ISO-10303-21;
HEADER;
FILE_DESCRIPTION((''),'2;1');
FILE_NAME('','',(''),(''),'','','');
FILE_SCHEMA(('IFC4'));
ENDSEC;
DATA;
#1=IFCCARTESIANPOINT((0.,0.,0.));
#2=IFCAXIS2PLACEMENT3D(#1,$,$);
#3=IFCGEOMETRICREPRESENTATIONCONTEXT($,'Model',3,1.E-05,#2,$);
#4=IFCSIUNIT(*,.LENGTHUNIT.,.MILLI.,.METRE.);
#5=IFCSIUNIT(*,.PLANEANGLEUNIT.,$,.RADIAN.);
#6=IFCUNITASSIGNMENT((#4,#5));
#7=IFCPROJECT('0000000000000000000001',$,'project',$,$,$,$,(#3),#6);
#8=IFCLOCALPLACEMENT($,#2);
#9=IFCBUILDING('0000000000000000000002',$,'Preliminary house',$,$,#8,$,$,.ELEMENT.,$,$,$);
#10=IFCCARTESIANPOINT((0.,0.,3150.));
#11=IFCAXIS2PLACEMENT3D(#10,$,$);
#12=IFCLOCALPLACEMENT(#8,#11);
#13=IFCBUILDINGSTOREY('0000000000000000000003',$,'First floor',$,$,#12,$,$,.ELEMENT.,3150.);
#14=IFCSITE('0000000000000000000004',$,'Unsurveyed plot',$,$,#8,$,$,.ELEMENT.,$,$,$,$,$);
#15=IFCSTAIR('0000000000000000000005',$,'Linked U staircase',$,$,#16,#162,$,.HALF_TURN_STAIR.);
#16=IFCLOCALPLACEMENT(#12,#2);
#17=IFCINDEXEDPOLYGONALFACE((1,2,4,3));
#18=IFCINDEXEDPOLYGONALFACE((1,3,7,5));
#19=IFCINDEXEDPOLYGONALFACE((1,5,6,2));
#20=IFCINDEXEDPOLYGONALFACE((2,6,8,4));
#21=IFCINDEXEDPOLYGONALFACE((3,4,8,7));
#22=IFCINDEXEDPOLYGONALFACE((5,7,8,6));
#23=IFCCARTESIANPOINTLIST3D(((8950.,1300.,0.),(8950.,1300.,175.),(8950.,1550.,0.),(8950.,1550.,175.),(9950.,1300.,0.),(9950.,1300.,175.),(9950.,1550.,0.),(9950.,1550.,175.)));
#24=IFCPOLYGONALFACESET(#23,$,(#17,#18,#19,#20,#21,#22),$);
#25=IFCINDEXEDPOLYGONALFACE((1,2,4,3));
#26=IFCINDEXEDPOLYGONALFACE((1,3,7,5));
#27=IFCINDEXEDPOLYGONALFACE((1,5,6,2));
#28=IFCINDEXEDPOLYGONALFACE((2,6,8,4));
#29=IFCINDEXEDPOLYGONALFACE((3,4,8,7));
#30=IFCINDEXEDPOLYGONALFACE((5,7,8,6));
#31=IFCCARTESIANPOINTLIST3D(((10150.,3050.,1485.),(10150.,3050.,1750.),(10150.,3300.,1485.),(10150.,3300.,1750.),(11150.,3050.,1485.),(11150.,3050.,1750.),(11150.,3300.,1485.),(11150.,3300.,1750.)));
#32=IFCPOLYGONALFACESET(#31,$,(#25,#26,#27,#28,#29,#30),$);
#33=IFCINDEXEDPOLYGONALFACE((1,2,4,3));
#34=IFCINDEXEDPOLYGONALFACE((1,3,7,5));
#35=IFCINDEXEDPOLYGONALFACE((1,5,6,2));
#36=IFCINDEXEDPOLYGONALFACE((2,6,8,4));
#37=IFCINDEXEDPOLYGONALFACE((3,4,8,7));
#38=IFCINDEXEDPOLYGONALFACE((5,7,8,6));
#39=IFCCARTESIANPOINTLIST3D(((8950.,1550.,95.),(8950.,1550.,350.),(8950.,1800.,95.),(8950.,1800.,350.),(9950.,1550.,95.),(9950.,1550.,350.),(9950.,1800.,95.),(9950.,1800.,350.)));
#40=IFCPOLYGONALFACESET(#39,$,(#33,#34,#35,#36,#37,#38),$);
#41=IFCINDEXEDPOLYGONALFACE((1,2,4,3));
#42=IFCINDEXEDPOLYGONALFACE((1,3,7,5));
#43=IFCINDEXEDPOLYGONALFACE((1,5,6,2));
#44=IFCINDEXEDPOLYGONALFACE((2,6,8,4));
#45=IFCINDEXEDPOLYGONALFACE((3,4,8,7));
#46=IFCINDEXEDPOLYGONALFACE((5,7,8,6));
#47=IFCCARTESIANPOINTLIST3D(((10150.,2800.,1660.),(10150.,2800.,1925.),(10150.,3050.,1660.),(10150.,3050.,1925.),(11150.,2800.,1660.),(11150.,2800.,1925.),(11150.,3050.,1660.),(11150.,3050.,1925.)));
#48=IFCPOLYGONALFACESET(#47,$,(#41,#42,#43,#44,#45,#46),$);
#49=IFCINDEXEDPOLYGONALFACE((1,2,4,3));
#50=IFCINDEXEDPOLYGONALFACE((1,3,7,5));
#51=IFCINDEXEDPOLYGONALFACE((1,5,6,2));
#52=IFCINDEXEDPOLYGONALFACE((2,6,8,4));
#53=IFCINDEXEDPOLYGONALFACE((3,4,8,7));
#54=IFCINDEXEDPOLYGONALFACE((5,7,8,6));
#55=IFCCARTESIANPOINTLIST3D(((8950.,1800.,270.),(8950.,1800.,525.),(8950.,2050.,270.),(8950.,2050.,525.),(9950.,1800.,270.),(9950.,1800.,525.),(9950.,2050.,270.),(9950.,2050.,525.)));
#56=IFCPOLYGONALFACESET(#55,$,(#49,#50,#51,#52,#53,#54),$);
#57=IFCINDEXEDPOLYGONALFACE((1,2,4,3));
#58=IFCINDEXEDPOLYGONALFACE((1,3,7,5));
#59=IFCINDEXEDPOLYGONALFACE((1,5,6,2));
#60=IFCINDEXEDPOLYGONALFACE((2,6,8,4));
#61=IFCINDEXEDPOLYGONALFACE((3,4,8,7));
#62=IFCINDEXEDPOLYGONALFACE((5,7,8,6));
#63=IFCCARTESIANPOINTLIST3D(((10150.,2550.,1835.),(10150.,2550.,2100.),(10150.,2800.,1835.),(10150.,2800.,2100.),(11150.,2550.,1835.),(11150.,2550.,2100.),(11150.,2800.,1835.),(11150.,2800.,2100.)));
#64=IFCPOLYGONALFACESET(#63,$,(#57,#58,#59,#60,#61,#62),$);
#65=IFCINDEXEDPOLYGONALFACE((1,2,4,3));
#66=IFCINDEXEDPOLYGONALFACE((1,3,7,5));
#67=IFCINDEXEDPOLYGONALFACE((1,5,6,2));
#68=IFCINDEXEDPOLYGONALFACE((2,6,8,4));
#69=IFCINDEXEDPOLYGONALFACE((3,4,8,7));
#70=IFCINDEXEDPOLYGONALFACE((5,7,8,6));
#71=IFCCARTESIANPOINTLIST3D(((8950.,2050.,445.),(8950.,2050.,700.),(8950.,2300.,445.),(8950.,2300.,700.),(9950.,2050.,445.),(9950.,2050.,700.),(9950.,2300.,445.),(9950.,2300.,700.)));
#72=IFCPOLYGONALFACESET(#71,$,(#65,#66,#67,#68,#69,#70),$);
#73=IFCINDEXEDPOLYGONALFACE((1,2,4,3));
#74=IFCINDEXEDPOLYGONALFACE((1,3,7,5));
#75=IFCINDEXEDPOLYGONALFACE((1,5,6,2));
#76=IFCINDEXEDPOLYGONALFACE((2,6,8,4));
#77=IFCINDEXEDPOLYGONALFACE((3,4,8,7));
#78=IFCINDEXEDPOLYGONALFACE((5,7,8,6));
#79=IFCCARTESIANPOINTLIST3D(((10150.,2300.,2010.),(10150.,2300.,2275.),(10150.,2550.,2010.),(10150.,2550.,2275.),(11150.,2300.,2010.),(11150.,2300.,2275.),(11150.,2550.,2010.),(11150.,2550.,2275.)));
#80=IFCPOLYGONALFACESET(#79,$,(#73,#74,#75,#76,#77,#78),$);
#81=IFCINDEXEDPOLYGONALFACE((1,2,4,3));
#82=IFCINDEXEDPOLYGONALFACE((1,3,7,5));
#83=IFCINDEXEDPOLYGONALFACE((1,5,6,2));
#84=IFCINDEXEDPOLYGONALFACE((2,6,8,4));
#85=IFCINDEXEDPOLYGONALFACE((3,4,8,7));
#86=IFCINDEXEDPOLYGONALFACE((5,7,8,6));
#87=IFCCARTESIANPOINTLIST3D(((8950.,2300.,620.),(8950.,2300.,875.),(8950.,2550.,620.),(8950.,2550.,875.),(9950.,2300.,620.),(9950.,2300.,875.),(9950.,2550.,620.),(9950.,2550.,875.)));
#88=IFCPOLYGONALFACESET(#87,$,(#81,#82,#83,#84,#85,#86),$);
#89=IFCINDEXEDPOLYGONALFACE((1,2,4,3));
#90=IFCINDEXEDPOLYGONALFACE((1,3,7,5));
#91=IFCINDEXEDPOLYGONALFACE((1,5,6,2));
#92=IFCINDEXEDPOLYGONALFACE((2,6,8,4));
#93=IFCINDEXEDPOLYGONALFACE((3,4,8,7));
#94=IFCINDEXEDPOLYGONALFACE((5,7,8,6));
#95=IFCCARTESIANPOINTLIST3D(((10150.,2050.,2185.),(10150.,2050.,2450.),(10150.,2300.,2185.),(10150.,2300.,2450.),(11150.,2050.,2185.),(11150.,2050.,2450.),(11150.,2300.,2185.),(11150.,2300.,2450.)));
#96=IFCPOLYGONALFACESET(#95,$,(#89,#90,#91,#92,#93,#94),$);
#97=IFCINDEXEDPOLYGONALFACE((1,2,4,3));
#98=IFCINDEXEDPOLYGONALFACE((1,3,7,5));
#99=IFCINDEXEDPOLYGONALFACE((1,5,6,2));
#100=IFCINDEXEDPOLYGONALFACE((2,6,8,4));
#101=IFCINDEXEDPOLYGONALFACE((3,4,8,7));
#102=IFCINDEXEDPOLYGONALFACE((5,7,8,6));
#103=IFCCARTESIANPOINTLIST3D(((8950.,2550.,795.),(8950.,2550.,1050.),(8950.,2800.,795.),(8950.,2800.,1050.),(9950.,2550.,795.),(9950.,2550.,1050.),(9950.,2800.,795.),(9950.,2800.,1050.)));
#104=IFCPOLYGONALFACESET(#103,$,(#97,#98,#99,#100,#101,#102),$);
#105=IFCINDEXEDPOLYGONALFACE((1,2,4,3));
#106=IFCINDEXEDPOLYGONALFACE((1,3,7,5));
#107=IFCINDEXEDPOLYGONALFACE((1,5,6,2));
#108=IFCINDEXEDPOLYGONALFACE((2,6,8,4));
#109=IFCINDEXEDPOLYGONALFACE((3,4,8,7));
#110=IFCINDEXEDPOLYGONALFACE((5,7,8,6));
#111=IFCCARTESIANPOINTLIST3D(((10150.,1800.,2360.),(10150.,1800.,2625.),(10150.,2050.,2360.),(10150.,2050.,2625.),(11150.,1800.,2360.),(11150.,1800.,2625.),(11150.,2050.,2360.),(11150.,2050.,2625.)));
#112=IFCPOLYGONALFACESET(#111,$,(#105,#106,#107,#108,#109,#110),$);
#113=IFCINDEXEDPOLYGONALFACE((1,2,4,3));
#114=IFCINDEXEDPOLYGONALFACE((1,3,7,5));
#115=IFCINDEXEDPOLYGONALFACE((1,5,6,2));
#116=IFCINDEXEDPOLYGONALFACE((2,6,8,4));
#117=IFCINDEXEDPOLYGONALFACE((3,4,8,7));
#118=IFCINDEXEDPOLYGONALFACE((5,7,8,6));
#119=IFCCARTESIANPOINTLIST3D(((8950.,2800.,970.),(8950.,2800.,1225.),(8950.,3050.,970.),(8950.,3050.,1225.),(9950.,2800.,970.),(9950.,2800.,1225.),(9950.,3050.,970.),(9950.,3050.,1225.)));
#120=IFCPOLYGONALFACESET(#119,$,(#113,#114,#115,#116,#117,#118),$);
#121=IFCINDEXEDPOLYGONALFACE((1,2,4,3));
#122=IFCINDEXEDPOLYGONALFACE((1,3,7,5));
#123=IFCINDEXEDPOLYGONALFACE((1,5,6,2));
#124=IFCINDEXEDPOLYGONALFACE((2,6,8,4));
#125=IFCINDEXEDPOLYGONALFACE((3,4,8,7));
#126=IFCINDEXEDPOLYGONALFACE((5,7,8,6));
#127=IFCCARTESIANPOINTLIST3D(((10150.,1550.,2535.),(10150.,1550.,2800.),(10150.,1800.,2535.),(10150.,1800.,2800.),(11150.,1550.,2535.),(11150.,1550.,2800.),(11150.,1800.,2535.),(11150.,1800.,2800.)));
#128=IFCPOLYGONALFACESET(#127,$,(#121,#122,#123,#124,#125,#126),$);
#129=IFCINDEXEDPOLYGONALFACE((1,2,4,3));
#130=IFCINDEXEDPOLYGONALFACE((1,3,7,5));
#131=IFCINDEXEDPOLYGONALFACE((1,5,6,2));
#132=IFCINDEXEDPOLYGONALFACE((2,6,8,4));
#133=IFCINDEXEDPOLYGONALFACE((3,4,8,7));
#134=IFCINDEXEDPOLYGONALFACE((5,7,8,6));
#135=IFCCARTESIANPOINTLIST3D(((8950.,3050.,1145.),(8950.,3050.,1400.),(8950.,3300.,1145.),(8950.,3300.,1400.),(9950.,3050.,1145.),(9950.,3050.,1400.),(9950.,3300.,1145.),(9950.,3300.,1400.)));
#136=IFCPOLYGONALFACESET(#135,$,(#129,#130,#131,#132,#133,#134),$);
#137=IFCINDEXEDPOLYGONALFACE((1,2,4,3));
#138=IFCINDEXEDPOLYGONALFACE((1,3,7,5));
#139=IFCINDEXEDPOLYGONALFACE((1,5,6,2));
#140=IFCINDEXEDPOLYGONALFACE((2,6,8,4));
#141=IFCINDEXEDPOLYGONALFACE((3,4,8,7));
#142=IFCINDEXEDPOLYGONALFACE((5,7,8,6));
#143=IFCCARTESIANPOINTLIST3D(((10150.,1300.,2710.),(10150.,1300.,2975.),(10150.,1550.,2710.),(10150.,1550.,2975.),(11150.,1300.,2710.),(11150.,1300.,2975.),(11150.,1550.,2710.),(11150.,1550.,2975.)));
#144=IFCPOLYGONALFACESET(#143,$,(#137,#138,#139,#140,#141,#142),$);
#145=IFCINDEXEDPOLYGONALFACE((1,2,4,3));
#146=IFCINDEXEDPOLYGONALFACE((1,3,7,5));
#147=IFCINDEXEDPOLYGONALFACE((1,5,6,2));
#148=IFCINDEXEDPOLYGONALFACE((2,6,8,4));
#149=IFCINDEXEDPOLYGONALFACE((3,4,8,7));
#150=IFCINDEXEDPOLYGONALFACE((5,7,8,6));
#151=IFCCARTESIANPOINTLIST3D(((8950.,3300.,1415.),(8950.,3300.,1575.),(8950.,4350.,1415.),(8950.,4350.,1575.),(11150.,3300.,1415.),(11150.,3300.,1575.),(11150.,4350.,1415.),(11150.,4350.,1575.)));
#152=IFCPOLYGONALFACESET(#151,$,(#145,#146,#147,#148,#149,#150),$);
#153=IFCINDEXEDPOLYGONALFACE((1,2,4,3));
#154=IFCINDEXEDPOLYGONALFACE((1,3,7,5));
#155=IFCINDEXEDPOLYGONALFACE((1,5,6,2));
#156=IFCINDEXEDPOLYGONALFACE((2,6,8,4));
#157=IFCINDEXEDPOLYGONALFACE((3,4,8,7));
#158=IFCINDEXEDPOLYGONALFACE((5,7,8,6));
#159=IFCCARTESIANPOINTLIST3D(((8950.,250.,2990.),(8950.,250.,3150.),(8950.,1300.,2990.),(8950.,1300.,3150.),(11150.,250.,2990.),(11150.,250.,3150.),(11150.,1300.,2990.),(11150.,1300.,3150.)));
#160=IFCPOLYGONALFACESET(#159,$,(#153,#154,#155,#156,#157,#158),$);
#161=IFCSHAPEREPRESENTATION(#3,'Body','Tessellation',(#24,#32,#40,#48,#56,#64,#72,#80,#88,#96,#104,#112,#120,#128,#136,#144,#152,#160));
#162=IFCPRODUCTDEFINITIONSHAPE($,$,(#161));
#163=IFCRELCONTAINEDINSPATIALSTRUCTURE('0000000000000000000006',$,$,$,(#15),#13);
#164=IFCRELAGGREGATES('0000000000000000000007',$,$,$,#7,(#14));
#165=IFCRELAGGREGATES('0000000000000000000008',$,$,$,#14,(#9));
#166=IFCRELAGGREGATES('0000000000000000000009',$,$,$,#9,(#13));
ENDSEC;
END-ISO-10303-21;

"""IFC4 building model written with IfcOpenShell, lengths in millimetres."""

from ifc_helpers import new_model, si_unit, frame, origin, place, context, project, spatial, polyline, outline, extrude, element, save


model = new_model("IFC4")

# Units and contexts
model_context = context("Model", 3, precision=1e-05, world=origin())
ifc_project = project(units=[si_unit("LENGTHUNIT", "METRE", prefix="MILLI"), si_unit("PLANEANGLEUNIT", "RADIAN")], contexts=[model_context])

# Site, building, storey
placement_1 = place(None, origin())
site = spatial("IfcSite", under=ifc_project, at=placement_1, Name="Unsurveyed plot", CompositionType="ELEMENT")
building = spatial("IfcBuilding", under=site, at=placement_1, Name="Preliminary house", CompositionType="ELEMENT")
placement_2 = place(placement_1, frame((0.0, 0.0, 3150.0)))
storey = spatial("IfcBuildingStorey", under=building, at=placement_2, Name="First floor", CompositionType="ELEMENT", Elevation=3150.0)

# Stair
element("IfcStair", 1, at=placement_2, inside=storey, Name="Linked U staircase", PredefinedType="HALF_TURN_STAIR", context=model_context, shape_type="SweptSolid", body=[
    extrude(outline(polyline([(9950.0, 1300.0), (9950.0, 1550.0), (8950.0, 1550.0), (8950.0, 1300.0), (9950.0, 1300.0)])), origin(), (0.0, 0.0, 1.0), 175.0),
    extrude(outline(polyline([(11150.0, 3050.0), (11150.0, 3300.0), (10150.0, 3300.0), (10150.0, 3050.0), (11150.0, 3050.0)])), frame((0.0, 0.0, 1485.0)), (0.0, 0.0, 1.0), 265.0),
    extrude(outline(polyline([(9950.0, 1550.0), (9950.0, 1800.0), (8950.0, 1800.0), (8950.0, 1550.0), (9950.0, 1550.0)])), frame((0.0, 0.0, 95.0)), (0.0, 0.0, 1.0), 255.0),
    extrude(outline(polyline([(11150.0, 2800.0), (11150.0, 3050.0), (10150.0, 3050.0), (10150.0, 2800.0), (11150.0, 2800.0)])), frame((0.0, 0.0, 1660.0)), (0.0, 0.0, 1.0), 265.0),
    extrude(outline(polyline([(9950.0, 1800.0), (9950.0, 2050.0), (8950.0, 2050.0), (8950.0, 1800.0), (9950.0, 1800.0)])), frame((0.0, 0.0, 270.0)), (0.0, 0.0, 1.0), 255.0),
    extrude(outline(polyline([(11150.0, 2550.0), (11150.0, 2800.0), (10150.0, 2800.0), (10150.0, 2550.0), (11150.0, 2550.0)])), frame((0.0, 0.0, 1835.0)), (0.0, 0.0, 1.0), 265.0),
    extrude(outline(polyline([(9950.0, 2050.0), (9950.0, 2300.0), (8950.0, 2300.0), (8950.0, 2050.0), (9950.0, 2050.0)])), frame((0.0, 0.0, 445.0)), (0.0, 0.0, 1.0), 255.0),
    extrude(outline(polyline([(11150.0, 2300.0), (11150.0, 2550.0), (10150.0, 2550.0), (10150.0, 2300.0), (11150.0, 2300.0)])), frame((0.0, 0.0, 2010.0)), (0.0, 0.0, 1.0), 265.0),
    extrude(outline(polyline([(9950.0, 2300.0), (9950.0, 2550.0), (8950.0, 2550.0), (8950.0, 2300.0), (9950.0, 2300.0)])), frame((0.0, 0.0, 620.0)), (0.0, 0.0, 1.0), 255.0),
    extrude(outline(polyline([(11150.0, 2050.0), (11150.0, 2300.0), (10150.0, 2300.0), (10150.0, 2050.0), (11150.0, 2050.0)])), frame((0.0, 0.0, 2185.0)), (0.0, 0.0, 1.0), 265.0),
    extrude(outline(polyline([(9950.0, 2550.0), (9950.0, 2800.0), (8950.0, 2800.0), (8950.0, 2550.0), (9950.0, 2550.0)])), frame((0.0, 0.0, 795.0)), (0.0, 0.0, 1.0), 255.0),
    extrude(outline(polyline([(11150.0, 1800.0), (11150.0, 2050.0), (10150.0, 2050.0), (10150.0, 1800.0), (11150.0, 1800.0)])), frame((0.0, 0.0, 2360.0)), (0.0, 0.0, 1.0), 265.0),
    extrude(outline(polyline([(9950.0, 2800.0), (9950.0, 3050.0), (8950.0, 3050.0), (8950.0, 2800.0), (9950.0, 2800.0)])), frame((0.0, 0.0, 970.0)), (0.0, 0.0, 1.0), 255.0),
    extrude(outline(polyline([(11150.0, 1550.0), (11150.0, 1800.0), (10150.0, 1800.0), (10150.0, 1550.0), (11150.0, 1550.0)])), frame((0.0, 0.0, 2535.0)), (0.0, 0.0, 1.0), 265.0),
    extrude(outline(polyline([(9950.0, 3050.0), (9950.0, 3300.0), (8950.0, 3300.0), (8950.0, 3050.0), (9950.0, 3050.0)])), frame((0.0, 0.0, 1145.0)), (0.0, 0.0, 1.0), 255.0),
    extrude(outline(polyline([(11150.0, 1300.0), (11150.0, 1550.0), (10150.0, 1550.0), (10150.0, 1300.0), (11150.0, 1300.0)])), frame((0.0, 0.0, 2710.0)), (0.0, 0.0, 1.0), 265.0),
    extrude(outline(polyline([(11150.0, 3300.0), (11150.0, 4350.0), (8950.0, 4350.0), (8950.0, 3300.0), (11150.0, 3300.0)])), frame((0.0, 0.0, 1415.0)), (0.0, 0.0, 1.0), 160.0),
    extrude(outline(polyline([(11150.0, 250.0), (11150.0, 1300.0), (8950.0, 1300.0), (8950.0, 250.0), (11150.0, 250.0)])), frame((0.0, 0.0, 2990.0)), (0.0, 0.0, 1.0), 160.0),
])

save(model, "model.ifc")
